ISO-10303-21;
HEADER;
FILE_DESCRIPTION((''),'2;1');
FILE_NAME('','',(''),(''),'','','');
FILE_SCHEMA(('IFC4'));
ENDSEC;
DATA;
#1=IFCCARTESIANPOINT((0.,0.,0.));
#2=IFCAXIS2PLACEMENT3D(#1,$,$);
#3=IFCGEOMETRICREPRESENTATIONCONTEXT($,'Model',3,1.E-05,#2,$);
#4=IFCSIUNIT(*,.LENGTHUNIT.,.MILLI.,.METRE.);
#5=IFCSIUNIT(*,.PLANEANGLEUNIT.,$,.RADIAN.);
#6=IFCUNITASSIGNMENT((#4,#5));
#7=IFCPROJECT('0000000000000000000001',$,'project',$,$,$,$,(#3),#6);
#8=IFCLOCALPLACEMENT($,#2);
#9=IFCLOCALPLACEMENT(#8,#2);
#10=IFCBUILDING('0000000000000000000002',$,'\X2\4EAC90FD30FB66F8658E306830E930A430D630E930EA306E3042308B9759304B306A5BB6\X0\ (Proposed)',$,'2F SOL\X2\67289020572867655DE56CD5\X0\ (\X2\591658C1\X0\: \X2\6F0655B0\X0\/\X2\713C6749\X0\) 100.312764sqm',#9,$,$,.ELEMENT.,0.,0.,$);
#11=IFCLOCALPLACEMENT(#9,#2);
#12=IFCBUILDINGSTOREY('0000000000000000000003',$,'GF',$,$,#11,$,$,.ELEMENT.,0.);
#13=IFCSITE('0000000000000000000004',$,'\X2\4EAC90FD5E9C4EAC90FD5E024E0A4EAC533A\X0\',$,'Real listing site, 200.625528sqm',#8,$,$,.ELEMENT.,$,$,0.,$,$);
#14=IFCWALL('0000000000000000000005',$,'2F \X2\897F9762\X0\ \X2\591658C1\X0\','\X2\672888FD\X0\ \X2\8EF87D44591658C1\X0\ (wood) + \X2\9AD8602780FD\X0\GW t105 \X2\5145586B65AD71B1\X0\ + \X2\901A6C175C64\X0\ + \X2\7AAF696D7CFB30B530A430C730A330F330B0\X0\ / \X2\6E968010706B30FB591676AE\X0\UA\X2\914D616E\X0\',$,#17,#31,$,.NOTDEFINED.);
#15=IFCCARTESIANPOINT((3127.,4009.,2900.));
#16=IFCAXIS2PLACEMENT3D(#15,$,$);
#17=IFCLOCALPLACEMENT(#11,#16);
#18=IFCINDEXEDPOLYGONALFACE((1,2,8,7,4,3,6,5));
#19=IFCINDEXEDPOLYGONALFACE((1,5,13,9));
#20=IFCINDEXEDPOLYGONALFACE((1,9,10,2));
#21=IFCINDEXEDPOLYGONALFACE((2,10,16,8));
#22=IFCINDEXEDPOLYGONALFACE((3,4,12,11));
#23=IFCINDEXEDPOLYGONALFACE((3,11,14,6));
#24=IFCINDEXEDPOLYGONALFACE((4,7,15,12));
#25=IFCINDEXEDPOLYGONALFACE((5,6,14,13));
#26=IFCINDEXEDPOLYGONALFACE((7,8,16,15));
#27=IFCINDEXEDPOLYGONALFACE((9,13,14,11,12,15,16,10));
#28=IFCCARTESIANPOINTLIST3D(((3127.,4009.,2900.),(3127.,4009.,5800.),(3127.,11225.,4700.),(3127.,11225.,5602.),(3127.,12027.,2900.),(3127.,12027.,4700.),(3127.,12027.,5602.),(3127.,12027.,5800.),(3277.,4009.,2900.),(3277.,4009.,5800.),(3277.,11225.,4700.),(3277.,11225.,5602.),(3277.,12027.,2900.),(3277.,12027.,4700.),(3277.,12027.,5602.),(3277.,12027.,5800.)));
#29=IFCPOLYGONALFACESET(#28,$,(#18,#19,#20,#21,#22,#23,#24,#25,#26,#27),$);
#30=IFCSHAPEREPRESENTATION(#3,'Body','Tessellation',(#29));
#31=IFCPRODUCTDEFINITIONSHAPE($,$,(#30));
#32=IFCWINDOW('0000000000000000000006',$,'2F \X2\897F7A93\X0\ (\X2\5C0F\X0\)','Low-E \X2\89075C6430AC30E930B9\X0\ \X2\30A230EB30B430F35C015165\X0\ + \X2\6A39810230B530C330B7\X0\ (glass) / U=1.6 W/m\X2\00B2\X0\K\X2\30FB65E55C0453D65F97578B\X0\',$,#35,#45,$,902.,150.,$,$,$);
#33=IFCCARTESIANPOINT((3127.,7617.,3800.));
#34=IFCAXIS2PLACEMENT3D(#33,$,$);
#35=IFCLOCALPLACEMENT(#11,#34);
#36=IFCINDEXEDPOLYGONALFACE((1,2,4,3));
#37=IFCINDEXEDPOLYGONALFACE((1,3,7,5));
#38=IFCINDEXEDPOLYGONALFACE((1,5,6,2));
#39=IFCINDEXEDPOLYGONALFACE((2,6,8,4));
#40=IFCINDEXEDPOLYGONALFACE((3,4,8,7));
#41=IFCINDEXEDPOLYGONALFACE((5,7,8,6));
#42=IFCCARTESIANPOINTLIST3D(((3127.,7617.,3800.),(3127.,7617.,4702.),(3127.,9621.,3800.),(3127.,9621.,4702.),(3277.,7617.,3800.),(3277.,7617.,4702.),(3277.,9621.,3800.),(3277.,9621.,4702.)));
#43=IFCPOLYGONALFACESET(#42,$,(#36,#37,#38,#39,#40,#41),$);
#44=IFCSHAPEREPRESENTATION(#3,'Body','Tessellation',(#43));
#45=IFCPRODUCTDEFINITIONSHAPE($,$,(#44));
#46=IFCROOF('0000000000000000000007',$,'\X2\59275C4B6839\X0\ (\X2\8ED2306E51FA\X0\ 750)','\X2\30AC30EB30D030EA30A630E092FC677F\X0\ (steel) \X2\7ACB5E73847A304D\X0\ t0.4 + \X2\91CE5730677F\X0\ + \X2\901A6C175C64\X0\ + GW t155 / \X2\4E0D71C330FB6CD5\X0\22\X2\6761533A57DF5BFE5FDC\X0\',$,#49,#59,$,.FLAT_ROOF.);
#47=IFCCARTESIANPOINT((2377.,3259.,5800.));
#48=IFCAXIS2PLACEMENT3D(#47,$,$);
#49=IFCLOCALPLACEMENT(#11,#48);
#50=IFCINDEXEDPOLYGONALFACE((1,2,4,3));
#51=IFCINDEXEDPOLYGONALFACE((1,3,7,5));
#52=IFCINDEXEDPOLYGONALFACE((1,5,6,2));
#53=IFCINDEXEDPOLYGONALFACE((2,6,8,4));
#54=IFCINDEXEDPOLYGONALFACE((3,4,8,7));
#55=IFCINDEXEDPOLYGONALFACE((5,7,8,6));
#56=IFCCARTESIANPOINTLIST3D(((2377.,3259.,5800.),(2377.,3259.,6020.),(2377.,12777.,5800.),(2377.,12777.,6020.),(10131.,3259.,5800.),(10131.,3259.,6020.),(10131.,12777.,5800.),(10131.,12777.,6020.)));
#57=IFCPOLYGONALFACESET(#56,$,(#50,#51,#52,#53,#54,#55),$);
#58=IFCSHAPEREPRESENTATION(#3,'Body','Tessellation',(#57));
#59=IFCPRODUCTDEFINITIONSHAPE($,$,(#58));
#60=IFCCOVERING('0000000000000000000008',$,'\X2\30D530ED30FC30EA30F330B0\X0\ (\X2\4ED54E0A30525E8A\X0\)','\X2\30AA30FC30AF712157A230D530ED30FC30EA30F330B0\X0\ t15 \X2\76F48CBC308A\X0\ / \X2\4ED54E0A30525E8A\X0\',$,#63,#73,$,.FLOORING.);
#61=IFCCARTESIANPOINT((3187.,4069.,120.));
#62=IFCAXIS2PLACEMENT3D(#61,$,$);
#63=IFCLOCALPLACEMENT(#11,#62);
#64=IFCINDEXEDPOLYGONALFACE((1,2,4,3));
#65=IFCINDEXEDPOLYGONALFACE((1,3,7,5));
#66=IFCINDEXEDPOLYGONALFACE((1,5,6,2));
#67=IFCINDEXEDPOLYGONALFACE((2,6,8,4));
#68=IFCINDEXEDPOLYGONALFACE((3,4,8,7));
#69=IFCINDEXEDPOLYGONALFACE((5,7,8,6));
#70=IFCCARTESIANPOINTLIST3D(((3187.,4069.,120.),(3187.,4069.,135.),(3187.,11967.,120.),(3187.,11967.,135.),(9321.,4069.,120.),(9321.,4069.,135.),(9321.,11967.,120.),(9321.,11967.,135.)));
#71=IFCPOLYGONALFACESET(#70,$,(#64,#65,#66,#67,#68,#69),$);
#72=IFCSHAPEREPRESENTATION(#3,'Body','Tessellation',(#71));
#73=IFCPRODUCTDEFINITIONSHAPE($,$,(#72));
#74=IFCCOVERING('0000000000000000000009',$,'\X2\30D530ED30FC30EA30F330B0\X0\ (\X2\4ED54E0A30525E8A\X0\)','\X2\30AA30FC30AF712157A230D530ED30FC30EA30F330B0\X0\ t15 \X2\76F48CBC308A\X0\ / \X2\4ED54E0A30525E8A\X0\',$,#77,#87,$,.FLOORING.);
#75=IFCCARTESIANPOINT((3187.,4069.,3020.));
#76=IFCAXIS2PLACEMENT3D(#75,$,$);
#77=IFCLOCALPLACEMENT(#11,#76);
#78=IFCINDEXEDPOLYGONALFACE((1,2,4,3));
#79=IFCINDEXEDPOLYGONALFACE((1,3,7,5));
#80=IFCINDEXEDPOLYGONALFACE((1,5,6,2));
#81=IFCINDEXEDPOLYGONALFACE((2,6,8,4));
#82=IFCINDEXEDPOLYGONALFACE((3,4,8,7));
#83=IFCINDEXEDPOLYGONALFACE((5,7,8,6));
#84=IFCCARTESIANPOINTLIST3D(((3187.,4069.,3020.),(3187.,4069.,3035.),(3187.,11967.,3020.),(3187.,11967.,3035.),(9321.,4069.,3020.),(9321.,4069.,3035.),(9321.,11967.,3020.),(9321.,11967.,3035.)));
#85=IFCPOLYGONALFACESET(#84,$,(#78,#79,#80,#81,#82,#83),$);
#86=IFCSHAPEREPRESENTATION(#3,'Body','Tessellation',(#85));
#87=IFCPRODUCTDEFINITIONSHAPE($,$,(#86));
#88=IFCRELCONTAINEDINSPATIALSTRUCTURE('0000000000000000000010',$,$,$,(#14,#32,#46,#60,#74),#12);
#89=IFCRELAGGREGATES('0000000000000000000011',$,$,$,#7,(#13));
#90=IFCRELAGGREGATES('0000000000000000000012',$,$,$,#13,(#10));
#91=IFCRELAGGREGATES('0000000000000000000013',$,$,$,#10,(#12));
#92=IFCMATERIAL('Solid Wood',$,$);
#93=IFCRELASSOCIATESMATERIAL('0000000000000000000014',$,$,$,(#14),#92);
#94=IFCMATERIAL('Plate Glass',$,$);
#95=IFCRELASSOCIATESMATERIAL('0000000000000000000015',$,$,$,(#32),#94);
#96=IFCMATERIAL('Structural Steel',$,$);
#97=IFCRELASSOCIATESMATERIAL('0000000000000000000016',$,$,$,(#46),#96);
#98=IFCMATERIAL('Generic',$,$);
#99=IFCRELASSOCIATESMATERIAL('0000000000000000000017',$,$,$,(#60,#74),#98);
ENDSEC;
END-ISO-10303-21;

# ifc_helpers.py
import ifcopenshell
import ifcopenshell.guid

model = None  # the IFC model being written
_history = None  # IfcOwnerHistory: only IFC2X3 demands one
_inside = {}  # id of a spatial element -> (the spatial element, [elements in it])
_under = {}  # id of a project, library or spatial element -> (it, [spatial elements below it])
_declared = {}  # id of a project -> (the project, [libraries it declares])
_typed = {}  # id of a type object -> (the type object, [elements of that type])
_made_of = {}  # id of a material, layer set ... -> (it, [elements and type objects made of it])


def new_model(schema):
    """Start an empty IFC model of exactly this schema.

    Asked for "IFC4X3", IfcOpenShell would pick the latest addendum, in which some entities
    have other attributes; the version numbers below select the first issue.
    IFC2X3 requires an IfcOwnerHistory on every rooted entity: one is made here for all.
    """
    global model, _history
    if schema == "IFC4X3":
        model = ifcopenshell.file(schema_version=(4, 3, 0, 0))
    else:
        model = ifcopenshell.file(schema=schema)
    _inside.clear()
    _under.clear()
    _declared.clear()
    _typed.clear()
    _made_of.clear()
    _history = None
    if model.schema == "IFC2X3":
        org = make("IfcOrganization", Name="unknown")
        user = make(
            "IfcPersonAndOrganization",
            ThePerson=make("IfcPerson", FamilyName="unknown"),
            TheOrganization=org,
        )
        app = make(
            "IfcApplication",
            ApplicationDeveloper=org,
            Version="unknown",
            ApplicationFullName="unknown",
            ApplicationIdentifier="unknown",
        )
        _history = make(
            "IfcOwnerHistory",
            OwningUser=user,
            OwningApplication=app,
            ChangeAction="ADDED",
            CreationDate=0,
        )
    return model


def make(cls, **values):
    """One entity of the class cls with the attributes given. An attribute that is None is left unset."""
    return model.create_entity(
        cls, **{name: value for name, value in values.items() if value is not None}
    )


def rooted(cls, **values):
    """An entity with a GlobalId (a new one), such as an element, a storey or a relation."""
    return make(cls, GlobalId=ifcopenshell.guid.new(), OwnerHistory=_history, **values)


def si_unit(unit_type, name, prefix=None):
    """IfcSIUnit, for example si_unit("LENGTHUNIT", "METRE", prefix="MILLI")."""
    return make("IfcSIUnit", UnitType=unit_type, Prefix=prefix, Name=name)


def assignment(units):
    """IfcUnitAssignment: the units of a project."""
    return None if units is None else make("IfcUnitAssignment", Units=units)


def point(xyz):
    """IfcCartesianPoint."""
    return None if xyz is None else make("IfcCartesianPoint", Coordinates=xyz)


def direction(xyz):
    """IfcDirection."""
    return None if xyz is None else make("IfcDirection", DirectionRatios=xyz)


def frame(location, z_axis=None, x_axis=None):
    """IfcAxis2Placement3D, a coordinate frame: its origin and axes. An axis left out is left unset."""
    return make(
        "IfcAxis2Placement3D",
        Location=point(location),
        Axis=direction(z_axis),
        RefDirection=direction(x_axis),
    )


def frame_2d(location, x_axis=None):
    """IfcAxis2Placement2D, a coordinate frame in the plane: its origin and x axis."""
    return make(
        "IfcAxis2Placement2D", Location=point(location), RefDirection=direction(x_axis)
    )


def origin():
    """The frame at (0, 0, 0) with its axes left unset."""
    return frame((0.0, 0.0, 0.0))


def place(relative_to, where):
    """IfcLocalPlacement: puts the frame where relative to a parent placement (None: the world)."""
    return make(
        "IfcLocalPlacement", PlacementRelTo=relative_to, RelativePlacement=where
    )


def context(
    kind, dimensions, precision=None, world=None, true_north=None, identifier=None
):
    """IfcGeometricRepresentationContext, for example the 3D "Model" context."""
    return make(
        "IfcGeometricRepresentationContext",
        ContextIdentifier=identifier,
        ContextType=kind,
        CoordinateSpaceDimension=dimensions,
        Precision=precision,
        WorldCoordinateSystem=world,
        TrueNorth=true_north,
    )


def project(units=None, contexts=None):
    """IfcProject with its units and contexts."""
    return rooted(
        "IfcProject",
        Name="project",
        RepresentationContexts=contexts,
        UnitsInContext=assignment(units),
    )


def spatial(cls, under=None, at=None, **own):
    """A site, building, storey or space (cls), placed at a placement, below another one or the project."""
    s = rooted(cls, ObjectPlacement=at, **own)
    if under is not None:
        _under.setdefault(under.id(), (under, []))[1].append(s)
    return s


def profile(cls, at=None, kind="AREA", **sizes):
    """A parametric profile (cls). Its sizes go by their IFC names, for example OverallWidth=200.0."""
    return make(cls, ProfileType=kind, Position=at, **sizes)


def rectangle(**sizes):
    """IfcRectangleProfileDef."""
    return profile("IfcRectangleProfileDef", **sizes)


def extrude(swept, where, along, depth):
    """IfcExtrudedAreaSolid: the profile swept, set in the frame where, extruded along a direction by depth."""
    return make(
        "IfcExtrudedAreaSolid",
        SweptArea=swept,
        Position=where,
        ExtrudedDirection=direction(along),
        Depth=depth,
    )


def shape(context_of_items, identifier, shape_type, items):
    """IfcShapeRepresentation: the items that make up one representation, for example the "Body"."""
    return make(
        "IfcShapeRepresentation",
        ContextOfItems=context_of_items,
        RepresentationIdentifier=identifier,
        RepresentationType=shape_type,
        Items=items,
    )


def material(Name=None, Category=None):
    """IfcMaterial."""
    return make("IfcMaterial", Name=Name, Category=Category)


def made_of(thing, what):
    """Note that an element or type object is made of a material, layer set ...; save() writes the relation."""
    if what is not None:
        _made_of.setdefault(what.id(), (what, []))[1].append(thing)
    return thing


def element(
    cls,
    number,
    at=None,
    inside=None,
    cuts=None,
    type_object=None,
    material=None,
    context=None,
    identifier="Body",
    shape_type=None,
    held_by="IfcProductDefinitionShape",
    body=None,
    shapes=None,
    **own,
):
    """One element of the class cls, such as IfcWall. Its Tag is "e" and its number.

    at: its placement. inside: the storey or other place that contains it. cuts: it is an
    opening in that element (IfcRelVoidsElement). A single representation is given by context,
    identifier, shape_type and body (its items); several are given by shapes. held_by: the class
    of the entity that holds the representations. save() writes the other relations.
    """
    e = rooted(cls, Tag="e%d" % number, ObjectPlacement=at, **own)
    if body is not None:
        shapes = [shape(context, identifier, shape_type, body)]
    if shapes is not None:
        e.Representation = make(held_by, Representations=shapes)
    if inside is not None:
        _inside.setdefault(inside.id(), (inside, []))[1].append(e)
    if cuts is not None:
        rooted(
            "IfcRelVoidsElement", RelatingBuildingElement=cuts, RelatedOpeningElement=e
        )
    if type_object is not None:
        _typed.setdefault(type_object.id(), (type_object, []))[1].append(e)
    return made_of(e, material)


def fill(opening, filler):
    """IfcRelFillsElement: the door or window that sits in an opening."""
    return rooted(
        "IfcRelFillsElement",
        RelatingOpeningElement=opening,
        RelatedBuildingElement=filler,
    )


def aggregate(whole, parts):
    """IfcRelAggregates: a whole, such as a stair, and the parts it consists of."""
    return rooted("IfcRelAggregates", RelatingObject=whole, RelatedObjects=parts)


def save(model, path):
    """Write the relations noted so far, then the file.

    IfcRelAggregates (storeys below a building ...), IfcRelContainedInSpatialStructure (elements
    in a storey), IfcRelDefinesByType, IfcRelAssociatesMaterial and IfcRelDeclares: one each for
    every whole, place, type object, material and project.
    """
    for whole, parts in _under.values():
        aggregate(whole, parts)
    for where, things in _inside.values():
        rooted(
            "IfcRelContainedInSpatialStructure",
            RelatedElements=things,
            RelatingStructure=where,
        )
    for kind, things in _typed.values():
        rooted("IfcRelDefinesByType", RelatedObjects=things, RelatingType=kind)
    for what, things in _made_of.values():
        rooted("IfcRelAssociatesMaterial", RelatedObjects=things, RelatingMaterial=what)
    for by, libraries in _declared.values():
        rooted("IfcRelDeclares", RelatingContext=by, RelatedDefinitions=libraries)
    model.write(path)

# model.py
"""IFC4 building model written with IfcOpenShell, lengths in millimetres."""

from ifc_helpers import new_model, si_unit, frame, frame_2d, origin, place, context, project, spatial, rectangle, extrude, material, element, fill, save


model = new_model("IFC4")

# Units and contexts
model_context = context("Model", 3, precision=1e-05, world=origin())
ifc_project = project(units=[si_unit("LENGTHUNIT", "METRE", prefix="MILLI"), si_unit("PLANEANGLEUNIT", "RADIAN")], contexts=[model_context])

# Site, building, storey
site_placement = place(None, origin())
site = spatial("IfcSite", under=ifc_project, at=site_placement, Name="京都府京都市上京区", ObjectType="Real listing site, 200.625528sqm", CompositionType="ELEMENT", RefElevation=0.0)
building_placement = place(site_placement, origin())
building = spatial("IfcBuilding", under=site, at=building_placement, Name="京都・書斎とライブラリのある静かな家 (Proposed)", ObjectType="2F SOL木造在来工法 (外壁: 漆喰/焼杉) 100.312764sqm", CompositionType="ELEMENT", ElevationOfRefHeight=0.0, ElevationOfTerrain=0.0)
storey_placement = place(building_placement, origin())
storey = spatial("IfcBuildingStorey", under=building, at=storey_placement, Name="GF", CompositionType="ELEMENT", Elevation=0.0)

# Shared definitions
ifc_material_1 = material(Name="Solid Wood")

# Shared definitions
ifc_material_2 = material(Name="Plate Glass")

# Wall, opening, window
wall_1_placement = place(storey_placement, frame((3127.0, 4009.0, 2900.0)))
wall_1 = element("IfcWall", 1, at=wall_1_placement, inside=storey, material=ifc_material_1, Name="2F 西面 外壁", Description="木製 軸組外壁 (wood) + 高性能GW t105 充填断熱 + 通気層 + 窯業系サイディング / 準耐火・外皮UA配慮", PredefinedType="NOTDEFINED", context=model_context, shape_type="SweptSolid", body=[
    extrude(rectangle(XDim=150.0, YDim=8018.0, at=frame_2d((75.0, 4009.0))), frame((3127.0, 4009.0, 2900.0)), (0.0, 0.0, 1.0), 2900.0),
])
opening_1_placement = place(storey_placement, frame((3127.0, 7617.0, 3800.0)))
opening_1 = element("IfcOpeningElement", 2, at=opening_1_placement, cuts=wall_1, PredefinedType="NOTDEFINED", context=model_context, shape_type="SweptSolid", body=[
    extrude(rectangle(XDim=150.0, YDim=2004.0, at=frame_2d((75.0, 1002.0))), frame((3127.0, 7617.0, 3800.0)), (0.0, 0.0, 1.0), 902.0),
])
window_1_placement = place(storey_placement, frame((3127.0, 7617.0, 3800.0)))
window_1 = element("IfcWindow", 3, at=window_1_placement, inside=storey, material=ifc_material_2, Name="2F 西窓 (小)", Description="Low-E 複層ガラス アルゴン封入 + 樹脂サッシ (glass) / U=1.6 W/m²K・日射取得型", OverallHeight=902.0, OverallWidth=150.0, context=model_context, shape_type="SweptSolid", body=[
    extrude(rectangle(XDim=150.0, YDim=2004.0, at=frame_2d((75.0, 1002.0))), frame((3127.0, 7617.0, 3800.0)), (0.0, 0.0, 1.0), 902.0),
])
fill(opening_1, window_1)

# Roof
ifc_material_3 = material(Name="Structural Steel")
roof_placement = place(storey_placement, frame((2377.0, 3259.0, 5800.0)))
element("IfcRoof", 4, at=roof_placement, inside=storey, material=ifc_material_3, Name="大屋根 (軒の出 750)", Description="ガルバリウム鋼板 (steel) 立平葺き t0.4 + 野地板 + 通気層 + GW t155 / 不燃・法22条区域対応", PredefinedType="FLAT_ROOF", context=model_context, shape_type="SweptSolid", body=[
    extrude(rectangle(XDim=7754.0, YDim=9518.0, at=frame_2d((3877.0, 4759.0))), frame((2377.0, 3259.0, 5800.0)), (0.0, 0.0, 1.0), 220.0),
])

# Coverings
ifc_material_4 = material(Name="Generic")
covering_1_placement = place(storey_placement, frame((3187.0, 4069.0, 120.0)))
element("IfcCovering", 5, at=covering_1_placement, inside=storey, material=ifc_material_4, Name="フローリング (仕上げ床)", Description="オーク無垢フローリング t15 直貼り / 仕上げ床", PredefinedType="FLOORING", context=model_context, shape_type="SweptSolid", body=[
    extrude(rectangle(XDim=6134.0, YDim=7898.0, at=frame_2d((3067.0, 3949.0))), frame((3187.0, 4069.0, 120.0)), (0.0, 0.0, 1.0), 15.0),
])
covering_2_placement = place(storey_placement, frame((3187.0, 4069.0, 3020.0)))
element("IfcCovering", 6, at=covering_2_placement, inside=storey, material=ifc_material_4, Name="フローリング (仕上げ床)", Description="オーク無垢フローリング t15 直貼り / 仕上げ床", PredefinedType="FLOORING", context=model_context, shape_type="SweptSolid", body=[
    extrude(rectangle(XDim=6134.0, YDim=7898.0, at=frame_2d((3067.0, 3949.0))), frame((3187.0, 4069.0, 3020.0)), (0.0, 0.0, 1.0), 15.0),
])

save(model, "model.ifc")
